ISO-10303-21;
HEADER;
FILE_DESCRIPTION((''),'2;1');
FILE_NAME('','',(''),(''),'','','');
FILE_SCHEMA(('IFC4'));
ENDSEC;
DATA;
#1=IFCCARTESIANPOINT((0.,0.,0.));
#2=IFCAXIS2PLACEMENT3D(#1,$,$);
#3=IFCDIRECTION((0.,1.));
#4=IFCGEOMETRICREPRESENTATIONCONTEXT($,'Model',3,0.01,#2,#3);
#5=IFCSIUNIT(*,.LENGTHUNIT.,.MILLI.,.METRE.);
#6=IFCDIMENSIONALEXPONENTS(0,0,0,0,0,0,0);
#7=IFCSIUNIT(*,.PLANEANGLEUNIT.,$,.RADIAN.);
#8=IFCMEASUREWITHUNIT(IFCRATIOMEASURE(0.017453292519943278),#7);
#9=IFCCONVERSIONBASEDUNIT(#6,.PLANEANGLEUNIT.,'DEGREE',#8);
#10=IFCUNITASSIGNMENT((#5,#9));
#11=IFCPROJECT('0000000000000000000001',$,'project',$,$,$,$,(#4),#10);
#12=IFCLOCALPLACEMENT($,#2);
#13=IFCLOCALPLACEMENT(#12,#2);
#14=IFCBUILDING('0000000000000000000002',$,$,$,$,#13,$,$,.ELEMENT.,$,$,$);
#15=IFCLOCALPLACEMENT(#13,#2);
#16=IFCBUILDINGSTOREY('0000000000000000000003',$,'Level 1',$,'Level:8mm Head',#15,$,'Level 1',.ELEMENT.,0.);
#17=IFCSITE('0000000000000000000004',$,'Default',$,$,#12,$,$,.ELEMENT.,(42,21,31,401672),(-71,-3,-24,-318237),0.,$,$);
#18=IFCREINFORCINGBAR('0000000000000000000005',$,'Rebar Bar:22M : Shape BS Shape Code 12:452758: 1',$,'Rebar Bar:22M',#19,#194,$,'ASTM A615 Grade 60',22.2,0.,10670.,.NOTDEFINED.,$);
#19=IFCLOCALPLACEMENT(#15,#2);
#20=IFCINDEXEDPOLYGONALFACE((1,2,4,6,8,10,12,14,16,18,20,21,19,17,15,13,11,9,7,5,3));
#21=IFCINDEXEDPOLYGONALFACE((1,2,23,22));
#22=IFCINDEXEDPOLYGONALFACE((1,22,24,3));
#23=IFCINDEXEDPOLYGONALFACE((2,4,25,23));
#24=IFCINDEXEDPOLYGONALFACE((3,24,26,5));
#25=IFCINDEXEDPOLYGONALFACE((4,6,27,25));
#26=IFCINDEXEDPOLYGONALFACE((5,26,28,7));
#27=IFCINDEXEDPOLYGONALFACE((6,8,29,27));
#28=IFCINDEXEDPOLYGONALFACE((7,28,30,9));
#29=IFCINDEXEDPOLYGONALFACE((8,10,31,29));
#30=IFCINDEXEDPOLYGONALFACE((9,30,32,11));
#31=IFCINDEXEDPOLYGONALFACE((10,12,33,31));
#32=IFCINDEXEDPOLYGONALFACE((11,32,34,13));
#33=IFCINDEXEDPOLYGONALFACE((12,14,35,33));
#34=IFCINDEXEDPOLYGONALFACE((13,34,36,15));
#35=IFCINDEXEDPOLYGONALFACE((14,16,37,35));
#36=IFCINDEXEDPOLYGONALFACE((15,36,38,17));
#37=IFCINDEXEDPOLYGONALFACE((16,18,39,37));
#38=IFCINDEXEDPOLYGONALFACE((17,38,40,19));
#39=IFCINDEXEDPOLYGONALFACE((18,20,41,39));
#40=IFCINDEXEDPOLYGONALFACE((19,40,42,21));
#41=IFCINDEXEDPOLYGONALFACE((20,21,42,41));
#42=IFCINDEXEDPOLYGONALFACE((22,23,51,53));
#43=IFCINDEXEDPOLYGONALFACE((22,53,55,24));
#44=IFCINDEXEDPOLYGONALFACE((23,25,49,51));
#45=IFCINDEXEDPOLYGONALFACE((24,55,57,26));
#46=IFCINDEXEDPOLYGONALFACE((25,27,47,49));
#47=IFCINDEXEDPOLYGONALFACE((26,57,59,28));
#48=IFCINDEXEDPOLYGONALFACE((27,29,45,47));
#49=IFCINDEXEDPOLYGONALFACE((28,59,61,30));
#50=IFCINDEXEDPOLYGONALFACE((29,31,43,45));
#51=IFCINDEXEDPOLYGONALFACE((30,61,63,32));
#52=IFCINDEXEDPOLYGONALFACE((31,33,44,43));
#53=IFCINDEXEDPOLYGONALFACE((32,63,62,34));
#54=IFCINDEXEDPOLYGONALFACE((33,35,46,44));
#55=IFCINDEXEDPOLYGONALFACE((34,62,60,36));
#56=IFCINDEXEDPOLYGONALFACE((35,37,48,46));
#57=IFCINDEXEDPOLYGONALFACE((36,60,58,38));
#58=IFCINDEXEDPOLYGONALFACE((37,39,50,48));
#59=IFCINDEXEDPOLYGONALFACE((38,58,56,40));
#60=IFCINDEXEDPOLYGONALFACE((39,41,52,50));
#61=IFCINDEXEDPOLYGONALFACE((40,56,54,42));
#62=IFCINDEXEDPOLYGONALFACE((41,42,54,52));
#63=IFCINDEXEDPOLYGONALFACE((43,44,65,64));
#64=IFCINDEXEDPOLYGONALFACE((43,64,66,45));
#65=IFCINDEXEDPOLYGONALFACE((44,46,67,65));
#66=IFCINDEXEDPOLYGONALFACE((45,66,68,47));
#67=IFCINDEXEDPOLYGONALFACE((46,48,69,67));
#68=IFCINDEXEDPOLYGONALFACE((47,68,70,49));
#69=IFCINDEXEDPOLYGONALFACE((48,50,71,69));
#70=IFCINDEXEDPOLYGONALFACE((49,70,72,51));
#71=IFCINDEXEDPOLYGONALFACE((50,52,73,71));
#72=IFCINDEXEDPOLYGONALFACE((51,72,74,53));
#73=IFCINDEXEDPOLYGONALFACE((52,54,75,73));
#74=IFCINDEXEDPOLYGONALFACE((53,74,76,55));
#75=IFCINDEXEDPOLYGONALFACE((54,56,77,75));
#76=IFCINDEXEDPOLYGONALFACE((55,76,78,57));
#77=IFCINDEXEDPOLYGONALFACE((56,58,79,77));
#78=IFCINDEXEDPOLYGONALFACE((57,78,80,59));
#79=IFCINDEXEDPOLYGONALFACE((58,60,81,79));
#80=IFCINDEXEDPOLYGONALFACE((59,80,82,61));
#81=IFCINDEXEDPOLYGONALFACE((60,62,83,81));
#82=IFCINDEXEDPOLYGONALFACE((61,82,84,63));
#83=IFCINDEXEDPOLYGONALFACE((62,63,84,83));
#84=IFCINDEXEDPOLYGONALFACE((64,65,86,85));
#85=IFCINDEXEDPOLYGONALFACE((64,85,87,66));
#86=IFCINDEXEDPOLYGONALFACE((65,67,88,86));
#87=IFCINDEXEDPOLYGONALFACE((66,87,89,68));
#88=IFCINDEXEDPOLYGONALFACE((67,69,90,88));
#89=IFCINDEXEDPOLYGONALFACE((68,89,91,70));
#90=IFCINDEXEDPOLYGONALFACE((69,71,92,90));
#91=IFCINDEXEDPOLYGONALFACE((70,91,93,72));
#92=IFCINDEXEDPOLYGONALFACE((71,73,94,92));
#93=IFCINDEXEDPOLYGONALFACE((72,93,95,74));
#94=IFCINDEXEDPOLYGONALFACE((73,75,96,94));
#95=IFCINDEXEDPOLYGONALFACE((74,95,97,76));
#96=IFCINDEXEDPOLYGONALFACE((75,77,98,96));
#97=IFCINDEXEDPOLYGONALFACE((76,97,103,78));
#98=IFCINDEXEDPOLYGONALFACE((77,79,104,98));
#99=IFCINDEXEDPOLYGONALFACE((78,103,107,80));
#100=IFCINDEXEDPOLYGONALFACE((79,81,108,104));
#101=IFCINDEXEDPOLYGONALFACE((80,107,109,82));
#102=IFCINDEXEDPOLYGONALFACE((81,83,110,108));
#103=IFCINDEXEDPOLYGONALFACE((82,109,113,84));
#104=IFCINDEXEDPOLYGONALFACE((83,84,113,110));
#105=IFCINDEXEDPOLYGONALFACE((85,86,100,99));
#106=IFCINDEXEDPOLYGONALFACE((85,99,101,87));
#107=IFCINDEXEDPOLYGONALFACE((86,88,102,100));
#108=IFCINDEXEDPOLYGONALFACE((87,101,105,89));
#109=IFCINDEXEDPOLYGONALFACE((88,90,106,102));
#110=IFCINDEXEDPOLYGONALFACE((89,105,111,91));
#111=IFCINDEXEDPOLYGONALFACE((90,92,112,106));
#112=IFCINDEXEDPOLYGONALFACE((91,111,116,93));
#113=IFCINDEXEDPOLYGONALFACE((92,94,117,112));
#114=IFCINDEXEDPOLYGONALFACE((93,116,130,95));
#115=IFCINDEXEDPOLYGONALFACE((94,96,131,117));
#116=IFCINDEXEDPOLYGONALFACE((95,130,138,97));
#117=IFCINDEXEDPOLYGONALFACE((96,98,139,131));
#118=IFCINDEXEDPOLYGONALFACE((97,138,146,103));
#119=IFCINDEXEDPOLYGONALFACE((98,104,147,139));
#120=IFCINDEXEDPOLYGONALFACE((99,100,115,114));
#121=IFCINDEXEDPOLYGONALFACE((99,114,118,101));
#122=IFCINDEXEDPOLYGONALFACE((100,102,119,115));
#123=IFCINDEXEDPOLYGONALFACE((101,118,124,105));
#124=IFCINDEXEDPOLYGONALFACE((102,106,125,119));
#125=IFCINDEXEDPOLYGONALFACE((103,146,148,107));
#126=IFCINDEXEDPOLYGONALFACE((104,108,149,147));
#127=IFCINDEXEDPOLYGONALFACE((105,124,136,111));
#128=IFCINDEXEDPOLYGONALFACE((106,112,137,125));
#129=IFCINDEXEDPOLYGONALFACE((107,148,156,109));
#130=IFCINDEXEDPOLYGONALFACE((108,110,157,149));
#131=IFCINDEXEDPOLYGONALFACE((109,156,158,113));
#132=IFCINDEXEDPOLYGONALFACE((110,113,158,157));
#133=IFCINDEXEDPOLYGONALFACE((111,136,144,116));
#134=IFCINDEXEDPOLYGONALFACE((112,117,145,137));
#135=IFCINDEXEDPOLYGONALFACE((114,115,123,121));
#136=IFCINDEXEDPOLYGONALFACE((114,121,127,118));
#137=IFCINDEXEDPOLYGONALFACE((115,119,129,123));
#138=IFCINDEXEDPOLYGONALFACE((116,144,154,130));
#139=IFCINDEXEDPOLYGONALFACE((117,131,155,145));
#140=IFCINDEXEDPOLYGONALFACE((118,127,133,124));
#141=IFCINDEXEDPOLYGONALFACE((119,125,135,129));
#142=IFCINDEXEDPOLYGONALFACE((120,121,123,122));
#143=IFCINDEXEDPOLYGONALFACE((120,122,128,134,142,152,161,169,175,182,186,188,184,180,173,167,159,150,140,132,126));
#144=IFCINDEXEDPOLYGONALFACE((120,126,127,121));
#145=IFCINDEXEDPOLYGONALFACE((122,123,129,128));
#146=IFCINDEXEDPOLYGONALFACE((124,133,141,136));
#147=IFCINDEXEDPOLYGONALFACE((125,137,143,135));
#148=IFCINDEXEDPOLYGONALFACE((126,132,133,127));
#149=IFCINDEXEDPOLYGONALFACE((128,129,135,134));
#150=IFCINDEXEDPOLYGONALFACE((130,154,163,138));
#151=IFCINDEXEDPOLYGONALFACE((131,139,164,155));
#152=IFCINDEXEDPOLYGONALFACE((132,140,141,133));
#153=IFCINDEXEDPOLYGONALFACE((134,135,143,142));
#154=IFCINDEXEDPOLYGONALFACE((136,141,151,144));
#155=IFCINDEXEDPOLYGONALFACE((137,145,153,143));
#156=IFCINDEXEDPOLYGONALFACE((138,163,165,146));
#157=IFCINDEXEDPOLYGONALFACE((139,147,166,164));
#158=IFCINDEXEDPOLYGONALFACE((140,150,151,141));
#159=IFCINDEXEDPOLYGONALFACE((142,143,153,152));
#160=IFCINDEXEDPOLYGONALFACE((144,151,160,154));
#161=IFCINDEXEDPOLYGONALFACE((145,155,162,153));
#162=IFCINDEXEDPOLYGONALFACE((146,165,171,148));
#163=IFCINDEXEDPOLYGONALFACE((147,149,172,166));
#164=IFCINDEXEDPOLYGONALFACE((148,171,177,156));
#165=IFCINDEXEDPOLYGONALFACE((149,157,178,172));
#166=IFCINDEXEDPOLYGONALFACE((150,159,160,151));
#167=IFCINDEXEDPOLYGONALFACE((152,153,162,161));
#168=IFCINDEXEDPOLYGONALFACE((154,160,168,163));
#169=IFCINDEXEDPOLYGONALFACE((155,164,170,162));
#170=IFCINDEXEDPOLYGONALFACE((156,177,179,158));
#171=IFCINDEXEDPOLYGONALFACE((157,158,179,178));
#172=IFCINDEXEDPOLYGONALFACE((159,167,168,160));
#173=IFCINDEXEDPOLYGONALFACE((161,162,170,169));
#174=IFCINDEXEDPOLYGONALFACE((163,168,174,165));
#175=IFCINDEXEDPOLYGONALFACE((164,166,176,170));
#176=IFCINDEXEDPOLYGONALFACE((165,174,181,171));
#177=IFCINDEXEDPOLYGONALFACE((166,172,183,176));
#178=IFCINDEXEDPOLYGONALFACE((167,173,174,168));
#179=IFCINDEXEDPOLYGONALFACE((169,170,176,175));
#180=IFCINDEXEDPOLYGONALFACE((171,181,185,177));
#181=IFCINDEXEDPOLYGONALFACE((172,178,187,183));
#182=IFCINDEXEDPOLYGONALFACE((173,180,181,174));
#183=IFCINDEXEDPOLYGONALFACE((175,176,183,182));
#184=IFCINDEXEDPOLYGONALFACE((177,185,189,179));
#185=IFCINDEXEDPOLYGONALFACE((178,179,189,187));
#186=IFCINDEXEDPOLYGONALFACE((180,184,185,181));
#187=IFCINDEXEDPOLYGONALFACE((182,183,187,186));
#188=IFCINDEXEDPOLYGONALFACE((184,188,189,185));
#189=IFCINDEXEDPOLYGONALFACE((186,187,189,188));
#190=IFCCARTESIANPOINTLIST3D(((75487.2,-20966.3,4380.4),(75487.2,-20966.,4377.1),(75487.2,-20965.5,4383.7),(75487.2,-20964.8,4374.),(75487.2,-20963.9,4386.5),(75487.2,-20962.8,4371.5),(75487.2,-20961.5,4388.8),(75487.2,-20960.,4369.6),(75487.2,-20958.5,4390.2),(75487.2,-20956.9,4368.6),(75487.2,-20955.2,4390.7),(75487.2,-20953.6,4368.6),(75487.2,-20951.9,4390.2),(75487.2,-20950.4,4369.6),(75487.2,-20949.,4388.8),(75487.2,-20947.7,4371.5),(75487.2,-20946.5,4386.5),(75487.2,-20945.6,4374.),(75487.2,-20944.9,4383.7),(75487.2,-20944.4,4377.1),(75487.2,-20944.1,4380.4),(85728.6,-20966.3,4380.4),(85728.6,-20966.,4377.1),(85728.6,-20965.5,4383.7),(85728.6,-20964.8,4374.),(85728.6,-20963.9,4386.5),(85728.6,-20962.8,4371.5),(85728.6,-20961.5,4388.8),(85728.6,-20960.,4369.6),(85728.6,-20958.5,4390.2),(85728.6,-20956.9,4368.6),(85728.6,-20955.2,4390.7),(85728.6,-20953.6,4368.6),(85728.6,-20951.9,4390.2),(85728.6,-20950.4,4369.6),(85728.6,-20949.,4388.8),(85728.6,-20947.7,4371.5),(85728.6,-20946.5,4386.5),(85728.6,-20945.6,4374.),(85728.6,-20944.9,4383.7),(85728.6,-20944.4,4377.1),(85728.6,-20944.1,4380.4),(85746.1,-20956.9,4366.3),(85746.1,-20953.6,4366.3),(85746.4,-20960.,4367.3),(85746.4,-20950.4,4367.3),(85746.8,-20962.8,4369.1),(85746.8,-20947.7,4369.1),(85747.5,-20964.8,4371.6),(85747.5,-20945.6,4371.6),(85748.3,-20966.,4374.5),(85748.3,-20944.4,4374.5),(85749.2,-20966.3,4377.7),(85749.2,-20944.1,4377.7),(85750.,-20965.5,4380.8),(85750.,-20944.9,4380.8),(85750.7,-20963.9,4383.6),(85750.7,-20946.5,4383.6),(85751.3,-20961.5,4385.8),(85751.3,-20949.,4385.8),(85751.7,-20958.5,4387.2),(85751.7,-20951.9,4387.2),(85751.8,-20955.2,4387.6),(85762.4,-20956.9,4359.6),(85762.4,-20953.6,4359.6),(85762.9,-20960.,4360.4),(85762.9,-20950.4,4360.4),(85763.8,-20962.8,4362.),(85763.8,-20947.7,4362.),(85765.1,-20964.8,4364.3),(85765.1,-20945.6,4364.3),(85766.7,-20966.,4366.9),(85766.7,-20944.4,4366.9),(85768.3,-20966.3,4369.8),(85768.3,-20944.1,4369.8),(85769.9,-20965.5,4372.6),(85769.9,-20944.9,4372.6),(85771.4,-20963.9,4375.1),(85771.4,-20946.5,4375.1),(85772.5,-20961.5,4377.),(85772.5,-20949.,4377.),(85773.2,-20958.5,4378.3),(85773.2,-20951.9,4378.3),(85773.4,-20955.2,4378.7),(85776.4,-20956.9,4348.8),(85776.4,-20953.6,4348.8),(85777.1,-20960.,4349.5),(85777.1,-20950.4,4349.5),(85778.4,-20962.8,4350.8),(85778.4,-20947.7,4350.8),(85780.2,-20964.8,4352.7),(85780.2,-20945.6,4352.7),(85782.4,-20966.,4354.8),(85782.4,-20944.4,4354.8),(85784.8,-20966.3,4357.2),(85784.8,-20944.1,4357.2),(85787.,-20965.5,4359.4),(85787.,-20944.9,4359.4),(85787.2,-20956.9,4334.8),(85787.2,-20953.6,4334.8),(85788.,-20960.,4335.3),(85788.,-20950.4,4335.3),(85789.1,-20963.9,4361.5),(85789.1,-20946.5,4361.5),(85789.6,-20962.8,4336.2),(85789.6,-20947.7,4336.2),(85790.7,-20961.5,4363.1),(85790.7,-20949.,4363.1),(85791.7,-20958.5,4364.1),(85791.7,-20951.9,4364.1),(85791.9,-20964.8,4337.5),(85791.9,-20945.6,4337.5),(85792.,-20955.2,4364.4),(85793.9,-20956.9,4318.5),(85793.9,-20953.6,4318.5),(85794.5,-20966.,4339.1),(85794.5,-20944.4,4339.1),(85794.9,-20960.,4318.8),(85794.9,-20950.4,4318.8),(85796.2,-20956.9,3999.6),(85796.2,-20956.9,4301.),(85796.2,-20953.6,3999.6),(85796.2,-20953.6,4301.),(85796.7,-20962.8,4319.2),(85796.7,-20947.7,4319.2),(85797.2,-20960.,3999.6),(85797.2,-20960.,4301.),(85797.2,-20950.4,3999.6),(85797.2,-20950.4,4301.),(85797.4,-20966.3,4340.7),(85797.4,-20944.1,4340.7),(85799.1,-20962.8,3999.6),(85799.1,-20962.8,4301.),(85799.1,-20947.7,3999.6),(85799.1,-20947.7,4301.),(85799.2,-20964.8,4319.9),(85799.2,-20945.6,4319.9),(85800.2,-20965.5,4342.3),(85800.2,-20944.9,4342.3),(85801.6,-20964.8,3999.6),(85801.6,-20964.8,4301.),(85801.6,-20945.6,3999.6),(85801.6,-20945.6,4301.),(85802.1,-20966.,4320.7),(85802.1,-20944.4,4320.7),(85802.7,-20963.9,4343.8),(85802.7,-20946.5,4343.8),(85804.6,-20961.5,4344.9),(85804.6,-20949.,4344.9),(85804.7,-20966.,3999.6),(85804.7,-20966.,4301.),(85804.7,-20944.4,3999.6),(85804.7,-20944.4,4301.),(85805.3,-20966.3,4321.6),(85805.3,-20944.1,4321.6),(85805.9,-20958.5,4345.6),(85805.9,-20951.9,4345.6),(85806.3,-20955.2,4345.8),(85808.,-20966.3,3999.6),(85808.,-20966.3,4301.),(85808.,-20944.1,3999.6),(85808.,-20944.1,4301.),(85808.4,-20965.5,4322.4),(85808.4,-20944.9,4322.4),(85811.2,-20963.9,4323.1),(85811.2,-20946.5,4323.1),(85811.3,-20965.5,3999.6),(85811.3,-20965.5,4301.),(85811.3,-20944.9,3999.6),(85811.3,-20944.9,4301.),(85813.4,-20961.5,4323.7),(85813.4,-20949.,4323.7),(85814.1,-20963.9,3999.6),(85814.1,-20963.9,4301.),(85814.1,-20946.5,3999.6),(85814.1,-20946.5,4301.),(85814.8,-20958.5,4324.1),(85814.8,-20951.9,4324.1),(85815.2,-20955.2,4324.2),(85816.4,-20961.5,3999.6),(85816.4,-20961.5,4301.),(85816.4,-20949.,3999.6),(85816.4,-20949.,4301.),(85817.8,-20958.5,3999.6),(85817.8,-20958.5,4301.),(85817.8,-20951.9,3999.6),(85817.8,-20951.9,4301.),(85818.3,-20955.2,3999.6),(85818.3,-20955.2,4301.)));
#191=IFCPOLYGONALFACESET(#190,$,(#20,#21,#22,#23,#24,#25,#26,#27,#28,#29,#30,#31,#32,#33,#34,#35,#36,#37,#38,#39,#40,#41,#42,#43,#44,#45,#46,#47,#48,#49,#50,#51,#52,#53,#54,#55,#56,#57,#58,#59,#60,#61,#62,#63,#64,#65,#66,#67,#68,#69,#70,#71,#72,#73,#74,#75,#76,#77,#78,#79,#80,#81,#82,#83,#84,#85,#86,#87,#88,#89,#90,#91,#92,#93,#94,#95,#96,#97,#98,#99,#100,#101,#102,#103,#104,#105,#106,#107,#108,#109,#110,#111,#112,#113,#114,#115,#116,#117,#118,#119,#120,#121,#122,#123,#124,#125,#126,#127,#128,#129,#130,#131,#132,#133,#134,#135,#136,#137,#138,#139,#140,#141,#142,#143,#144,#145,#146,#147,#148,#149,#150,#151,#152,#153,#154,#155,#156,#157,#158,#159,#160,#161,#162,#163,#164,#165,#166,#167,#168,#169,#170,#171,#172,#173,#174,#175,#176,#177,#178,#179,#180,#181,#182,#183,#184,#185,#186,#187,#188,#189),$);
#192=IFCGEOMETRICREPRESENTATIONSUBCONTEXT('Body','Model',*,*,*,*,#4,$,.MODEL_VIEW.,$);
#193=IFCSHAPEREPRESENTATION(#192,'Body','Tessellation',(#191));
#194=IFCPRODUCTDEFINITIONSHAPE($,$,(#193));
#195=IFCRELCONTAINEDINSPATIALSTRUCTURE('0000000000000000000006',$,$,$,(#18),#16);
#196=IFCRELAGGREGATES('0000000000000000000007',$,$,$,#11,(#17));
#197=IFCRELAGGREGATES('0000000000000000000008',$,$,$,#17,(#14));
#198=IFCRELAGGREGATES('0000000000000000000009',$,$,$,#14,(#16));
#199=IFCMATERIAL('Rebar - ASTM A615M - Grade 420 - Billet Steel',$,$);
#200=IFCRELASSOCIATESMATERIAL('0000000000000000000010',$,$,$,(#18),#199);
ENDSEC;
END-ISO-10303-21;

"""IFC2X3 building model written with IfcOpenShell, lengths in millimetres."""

from ifc_helpers import new_model, entity, si_unit, converted_unit, direction, origin, place, context, subcontext, project, spatial, material, element, save


model = new_model("IFC2X3")

# Units and contexts
model_context = context("Model", 3, precision=0.01, world=origin(), true_north=direction((0.0, 1.0)))
body_context = subcontext(model_context, "Body", "Model", "MODEL_VIEW")
ifc_project = project(units=[si_unit("LENGTHUNIT", "METRE", prefix="MILLI"), converted_unit("PLANEANGLEUNIT", "DEGREE", entity("IfcRatioMeasure", 0.017453292519943278), si_unit("PLANEANGLEUNIT", "RADIAN"), dimensions=[0, 0, 0, 0, 0, 0, 0])], contexts=[model_context])

# Site, building, storey
site_placement = place(None, origin())
site = spatial("IfcSite", under=ifc_project, at=site_placement, Name="Default", CompositionType="ELEMENT", RefLatitude=(42, 21, 31, 401672), RefLongitude=(-71, -3, -24, -318237), RefElevation=0.0)
building_placement = place(site_placement, origin())
building = spatial("IfcBuilding", under=site, at=building_placement, CompositionType="ELEMENT")
storey_placement = place(building_placement, origin())
storey = spatial("IfcBuildingStorey", under=building, at=storey_placement, Name="Level 1", ObjectType="Level:8mm Head", LongName="Level 1", CompositionType="ELEMENT", Elevation=0.0)

# Reinforcing bar
ifc_material = material(Name="Rebar - ASTM A615M - Grade 420 - Billet Steel")
reinforcing_bar_1_placement = place(storey_placement, origin())
element("IfcReinforcingBar", 1, at=reinforcing_bar_1_placement, inside=storey, material=ifc_material, Name="Rebar Bar:22M : Shape BS Shape Code 12:452758: 1", SteelGrade="ASTM A615 Grade 60", ObjectType="Rebar Bar:22M", BarLength=10670.0, BarRole="NOTDEFINED", CrossSectionArea=0.0, NominalDiameter=22.2, context=body_context, shape_type="AdvancedSweptSolid", body=[
    entity("IfcSweptDiskSolid", entity("IfcCompositeCurve", [entity("IfcCompositeCurveSegment", "CONTINUOUS", True, entity("IfcPolyline", [entity("IfcCartesianPoint", [75487.2, -20955.2, 4379.6]), entity("IfcCartesianPoint", [85728.6, -20955.2, 4379.6])])), entity("IfcCompositeCurveSegment", "CONTINUOUS", True, entity("IfcTrimmedCurve", entity("IfcCircle", entity("IfcAxis2Placement3D", entity("IfcCartesianPoint", [85728.6, -20955.2, 4301.0]), entity("IfcDirection", [0.0, 1.0, 0.0]), entity("IfcDirection", [1.0, 0.0, 0.0])), 78.6), [entity("IfcParameterValue", 270.0)], [entity("IfcParameterValue", 360.0)], True, "PARAMETER")), entity("IfcCompositeCurveSegment", "CONTINUOUS", True, entity("IfcPolyline", [entity("IfcCartesianPoint", [85807.2, -20955.2, 4301.0]), entity("IfcCartesianPoint", [85807.2, -20955.2, 3999.6])]))], False), 11.1, None, 0.0, 92.0),
])

save(model, "model.ifc")
